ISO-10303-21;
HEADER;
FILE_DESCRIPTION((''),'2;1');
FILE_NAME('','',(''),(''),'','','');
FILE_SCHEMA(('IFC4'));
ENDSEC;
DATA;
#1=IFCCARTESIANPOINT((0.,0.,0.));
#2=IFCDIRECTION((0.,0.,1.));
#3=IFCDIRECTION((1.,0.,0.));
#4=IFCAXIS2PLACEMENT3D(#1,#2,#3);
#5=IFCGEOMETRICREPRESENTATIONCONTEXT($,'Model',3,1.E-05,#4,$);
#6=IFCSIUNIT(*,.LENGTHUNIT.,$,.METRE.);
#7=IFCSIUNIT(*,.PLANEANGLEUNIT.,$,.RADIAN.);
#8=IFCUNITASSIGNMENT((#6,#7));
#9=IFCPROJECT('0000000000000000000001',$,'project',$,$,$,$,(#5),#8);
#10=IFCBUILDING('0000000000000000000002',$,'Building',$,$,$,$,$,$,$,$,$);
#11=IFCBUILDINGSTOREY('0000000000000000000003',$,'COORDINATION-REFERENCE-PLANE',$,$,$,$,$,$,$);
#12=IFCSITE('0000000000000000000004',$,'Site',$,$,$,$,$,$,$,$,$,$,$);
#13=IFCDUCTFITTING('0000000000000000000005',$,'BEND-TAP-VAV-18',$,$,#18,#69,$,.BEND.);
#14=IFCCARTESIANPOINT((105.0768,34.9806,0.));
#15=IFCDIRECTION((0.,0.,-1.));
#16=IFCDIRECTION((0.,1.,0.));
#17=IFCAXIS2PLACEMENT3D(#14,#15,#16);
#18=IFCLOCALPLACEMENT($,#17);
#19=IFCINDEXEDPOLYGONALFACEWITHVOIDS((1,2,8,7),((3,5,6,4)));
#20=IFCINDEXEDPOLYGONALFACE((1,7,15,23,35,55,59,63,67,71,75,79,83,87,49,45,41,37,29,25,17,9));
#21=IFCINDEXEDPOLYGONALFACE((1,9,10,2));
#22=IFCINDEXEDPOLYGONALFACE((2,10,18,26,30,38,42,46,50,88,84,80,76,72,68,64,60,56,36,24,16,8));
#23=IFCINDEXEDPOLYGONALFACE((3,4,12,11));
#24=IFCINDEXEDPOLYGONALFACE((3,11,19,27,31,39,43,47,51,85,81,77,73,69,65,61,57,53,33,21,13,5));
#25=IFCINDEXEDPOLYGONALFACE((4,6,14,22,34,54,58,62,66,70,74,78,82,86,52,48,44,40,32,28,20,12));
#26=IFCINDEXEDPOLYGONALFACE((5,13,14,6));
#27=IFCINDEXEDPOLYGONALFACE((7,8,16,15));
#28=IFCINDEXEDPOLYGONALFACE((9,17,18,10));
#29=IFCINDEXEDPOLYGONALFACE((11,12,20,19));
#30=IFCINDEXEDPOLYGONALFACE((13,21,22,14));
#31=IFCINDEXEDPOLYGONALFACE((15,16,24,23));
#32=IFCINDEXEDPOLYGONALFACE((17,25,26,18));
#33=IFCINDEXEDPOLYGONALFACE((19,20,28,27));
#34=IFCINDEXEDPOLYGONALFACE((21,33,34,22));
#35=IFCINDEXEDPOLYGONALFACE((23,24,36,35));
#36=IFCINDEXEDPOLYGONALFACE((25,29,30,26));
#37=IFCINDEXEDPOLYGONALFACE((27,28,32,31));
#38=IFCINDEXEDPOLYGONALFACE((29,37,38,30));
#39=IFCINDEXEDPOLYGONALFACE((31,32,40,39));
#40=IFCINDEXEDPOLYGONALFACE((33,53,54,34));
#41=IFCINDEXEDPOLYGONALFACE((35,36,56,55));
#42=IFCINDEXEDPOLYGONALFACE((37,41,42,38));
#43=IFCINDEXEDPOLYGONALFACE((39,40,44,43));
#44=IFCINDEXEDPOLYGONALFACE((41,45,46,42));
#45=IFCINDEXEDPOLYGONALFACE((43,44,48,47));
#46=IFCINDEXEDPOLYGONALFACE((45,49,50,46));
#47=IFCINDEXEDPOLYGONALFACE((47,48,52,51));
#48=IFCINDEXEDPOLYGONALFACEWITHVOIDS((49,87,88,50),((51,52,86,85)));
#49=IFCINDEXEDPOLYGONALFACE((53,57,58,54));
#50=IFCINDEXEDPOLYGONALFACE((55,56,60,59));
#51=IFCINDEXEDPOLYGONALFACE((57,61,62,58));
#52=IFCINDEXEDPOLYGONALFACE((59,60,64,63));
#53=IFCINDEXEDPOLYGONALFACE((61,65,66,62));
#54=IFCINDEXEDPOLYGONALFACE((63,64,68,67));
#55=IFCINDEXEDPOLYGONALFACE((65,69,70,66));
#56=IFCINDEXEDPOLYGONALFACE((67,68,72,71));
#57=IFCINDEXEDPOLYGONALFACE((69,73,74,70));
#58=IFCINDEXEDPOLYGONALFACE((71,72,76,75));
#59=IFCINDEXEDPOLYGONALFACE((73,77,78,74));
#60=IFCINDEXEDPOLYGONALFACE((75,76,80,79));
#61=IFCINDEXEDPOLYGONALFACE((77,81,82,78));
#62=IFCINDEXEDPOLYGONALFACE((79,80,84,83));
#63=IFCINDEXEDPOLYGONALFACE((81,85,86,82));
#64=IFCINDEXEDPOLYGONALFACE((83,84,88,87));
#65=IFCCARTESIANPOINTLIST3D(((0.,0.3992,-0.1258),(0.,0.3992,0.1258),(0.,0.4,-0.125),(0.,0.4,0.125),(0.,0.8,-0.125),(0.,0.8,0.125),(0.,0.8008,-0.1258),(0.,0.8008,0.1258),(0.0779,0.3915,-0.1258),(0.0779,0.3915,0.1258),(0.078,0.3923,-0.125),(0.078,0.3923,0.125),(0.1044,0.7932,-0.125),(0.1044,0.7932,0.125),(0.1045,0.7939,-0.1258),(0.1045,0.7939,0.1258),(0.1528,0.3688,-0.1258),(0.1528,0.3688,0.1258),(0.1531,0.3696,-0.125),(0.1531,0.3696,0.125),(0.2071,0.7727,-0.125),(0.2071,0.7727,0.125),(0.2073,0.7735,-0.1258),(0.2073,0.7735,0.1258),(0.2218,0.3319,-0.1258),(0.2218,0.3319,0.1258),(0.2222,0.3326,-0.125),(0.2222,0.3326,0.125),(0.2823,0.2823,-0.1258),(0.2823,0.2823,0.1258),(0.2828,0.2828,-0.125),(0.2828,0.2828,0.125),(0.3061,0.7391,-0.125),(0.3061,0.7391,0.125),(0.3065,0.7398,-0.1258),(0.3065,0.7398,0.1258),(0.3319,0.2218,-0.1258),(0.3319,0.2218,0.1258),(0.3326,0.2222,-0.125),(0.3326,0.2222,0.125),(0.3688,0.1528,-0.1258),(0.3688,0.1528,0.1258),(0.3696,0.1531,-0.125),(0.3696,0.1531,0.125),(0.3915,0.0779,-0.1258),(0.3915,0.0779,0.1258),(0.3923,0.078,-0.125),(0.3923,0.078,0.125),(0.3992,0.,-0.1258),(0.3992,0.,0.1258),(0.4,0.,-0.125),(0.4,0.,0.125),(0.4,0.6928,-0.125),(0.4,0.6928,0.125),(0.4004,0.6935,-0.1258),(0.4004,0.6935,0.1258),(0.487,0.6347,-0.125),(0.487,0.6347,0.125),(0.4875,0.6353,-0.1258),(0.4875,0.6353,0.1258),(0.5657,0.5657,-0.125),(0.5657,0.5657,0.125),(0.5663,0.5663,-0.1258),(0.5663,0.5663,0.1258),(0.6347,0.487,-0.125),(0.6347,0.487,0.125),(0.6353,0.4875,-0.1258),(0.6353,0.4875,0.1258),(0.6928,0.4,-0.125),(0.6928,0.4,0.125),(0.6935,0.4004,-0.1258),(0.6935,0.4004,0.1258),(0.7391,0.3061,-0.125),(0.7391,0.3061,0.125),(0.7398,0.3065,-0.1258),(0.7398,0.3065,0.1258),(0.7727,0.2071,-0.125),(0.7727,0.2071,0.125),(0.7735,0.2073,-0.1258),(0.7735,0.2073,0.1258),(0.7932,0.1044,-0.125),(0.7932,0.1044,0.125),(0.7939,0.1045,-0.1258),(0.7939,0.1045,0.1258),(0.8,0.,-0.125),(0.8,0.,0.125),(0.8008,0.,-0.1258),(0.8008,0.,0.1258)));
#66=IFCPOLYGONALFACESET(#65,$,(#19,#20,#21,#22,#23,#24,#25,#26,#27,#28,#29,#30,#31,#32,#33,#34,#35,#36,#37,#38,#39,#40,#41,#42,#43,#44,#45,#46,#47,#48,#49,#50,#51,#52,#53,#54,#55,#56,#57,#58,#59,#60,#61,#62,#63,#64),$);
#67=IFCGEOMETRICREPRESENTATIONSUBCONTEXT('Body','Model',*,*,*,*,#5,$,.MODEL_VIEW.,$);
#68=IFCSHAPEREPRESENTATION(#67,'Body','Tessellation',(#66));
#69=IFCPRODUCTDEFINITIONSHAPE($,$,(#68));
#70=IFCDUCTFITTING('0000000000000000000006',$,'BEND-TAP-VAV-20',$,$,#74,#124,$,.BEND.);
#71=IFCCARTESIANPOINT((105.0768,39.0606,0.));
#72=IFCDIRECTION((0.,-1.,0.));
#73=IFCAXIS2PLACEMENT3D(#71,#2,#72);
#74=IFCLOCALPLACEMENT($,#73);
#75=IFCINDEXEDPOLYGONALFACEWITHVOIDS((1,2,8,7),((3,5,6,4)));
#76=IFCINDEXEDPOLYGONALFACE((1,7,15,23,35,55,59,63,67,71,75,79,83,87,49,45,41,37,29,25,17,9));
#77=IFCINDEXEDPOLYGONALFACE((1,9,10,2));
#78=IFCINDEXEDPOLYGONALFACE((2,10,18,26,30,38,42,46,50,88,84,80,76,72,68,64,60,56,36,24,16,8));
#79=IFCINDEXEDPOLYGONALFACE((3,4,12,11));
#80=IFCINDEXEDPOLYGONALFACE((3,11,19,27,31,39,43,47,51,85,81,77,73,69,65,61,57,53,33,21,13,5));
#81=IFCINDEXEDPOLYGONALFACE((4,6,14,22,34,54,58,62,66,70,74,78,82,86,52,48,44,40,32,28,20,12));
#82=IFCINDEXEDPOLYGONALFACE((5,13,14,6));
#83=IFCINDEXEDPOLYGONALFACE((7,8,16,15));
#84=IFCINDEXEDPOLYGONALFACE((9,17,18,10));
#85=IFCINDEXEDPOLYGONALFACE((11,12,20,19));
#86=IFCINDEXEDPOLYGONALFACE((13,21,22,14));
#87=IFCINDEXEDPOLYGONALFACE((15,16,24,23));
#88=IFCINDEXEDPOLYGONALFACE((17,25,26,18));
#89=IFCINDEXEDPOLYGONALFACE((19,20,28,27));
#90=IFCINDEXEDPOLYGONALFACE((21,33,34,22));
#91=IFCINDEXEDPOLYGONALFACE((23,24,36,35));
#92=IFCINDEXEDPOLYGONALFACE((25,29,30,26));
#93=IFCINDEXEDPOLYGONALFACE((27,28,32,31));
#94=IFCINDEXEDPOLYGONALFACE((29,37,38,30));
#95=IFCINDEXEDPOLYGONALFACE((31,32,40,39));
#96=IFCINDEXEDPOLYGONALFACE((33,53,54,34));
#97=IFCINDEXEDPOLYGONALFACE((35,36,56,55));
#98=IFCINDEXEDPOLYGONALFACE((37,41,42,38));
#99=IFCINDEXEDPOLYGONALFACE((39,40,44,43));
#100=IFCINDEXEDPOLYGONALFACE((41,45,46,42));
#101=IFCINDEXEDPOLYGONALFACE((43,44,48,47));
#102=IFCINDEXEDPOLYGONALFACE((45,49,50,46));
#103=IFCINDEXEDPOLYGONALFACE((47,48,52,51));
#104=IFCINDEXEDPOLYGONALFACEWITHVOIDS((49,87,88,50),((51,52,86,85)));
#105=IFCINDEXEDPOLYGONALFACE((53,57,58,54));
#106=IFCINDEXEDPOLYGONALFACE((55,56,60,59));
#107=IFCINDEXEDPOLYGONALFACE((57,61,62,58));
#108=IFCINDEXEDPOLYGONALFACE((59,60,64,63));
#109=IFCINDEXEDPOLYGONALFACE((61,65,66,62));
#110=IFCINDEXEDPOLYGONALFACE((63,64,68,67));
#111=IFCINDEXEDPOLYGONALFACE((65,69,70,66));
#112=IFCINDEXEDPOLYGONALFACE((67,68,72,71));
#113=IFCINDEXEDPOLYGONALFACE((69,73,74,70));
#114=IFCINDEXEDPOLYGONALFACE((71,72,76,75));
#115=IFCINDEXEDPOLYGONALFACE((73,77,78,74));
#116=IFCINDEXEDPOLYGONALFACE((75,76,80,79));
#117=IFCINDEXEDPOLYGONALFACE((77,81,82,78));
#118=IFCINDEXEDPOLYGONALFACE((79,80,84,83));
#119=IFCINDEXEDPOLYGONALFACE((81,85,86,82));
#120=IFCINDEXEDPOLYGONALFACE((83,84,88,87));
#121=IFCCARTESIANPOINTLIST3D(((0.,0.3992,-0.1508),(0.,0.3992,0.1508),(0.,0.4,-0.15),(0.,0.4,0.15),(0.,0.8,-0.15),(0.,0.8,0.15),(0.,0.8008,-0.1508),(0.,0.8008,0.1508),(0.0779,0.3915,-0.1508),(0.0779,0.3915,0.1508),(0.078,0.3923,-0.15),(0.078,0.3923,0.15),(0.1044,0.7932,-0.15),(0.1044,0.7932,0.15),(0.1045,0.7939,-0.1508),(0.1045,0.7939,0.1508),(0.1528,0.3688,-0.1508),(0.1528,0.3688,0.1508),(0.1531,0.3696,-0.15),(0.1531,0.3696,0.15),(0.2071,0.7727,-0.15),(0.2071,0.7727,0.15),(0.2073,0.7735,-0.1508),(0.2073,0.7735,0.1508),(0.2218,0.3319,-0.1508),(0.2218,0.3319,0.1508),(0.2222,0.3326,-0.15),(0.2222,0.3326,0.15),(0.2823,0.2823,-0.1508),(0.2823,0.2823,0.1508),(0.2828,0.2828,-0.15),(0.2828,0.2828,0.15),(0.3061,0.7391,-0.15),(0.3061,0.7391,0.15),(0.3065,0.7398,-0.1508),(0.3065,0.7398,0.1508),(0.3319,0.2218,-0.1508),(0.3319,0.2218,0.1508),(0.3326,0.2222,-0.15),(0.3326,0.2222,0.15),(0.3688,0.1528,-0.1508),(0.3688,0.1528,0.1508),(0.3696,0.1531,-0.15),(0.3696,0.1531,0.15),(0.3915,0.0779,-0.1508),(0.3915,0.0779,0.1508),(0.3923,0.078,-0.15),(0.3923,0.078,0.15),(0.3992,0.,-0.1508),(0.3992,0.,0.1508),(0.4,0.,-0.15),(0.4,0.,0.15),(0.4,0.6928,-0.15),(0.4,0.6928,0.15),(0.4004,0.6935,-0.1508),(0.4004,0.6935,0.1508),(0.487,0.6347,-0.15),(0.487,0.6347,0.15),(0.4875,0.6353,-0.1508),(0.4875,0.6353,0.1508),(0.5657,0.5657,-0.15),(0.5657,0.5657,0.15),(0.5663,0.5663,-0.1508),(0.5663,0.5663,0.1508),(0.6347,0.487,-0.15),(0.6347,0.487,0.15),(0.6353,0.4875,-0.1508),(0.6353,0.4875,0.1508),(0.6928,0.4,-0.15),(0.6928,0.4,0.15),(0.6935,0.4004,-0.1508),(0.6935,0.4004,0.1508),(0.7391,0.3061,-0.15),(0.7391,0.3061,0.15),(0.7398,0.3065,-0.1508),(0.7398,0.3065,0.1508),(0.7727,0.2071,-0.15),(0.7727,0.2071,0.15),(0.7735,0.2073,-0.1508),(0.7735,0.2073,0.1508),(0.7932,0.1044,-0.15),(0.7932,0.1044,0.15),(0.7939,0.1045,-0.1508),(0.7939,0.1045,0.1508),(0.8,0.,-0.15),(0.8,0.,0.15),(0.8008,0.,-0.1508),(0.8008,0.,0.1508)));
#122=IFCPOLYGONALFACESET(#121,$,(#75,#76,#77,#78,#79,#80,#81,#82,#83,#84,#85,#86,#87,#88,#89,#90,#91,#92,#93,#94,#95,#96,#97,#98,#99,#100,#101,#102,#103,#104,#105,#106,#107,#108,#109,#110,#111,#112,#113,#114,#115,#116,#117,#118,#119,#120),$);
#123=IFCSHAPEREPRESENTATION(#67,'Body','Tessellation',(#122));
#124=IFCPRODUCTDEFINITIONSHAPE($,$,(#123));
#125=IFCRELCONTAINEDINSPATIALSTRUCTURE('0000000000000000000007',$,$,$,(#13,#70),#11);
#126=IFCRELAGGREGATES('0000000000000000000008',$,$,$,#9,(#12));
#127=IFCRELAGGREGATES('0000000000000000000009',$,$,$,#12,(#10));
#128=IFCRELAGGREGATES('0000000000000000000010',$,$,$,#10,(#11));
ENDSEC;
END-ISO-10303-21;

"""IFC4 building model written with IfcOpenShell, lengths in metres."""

from ifc_helpers import new_model, entity, si_unit, frame, origin_with_axes, place, context, subcontext, project, spatial, element, save


model = new_model("IFC4")

# Units and contexts
model_context = context("Model", 3, precision=1e-05, world=origin_with_axes())
body_context_1 = subcontext(model_context, "Body", "Model", "MODEL_VIEW")
ifc_project = project(units=[si_unit("LENGTHUNIT", "METRE"), si_unit("PLANEANGLEUNIT", "RADIAN")], contexts=[model_context])

# Site, building, storey
site = spatial("IfcSite", under=ifc_project, Name="Site")
building = spatial("IfcBuilding", under=site, Name="Building")
storey = spatial("IfcBuildingStorey", under=building, Name="COORDINATION-REFERENCE-PLANE")

# Duct fittings
duct_fitting_1_placement = place(None, frame((105.0768, 34.9806, 0.0), z_axis=(0.0, 0.0, -1.0), x_axis=(0.0, 1.0, 0.0)))
cartesian_point_1 = entity("IfcCartesianPoint", [0.0, 0.0, 0.0])
element("IfcDuctFitting", 1, at=duct_fitting_1_placement, inside=storey, Name="BEND-TAP-VAV-18", PredefinedType="BEND", context=body_context_1, shape_type="SweptSolid", body=[
    entity("IfcRevolvedAreaSolid", entity("IfcRectangleHollowProfileDef", "AREA", None, entity("IfcAxis2Placement2D", entity("IfcCartesianPoint", [0.6, 0.0])), 0.4016, 0.2516, 0.0008), entity("IfcAxis2Placement3D", cartesian_point_1, entity("IfcDirection", [0.0, -1.0, 0.0]), entity("IfcDirection", [1.0, 0.0, 0.0])), entity("IfcAxis1Placement", cartesian_point_1, entity("IfcDirection", [0.0, 1.0, 0.0])), 1.570796),
])
duct_fitting_2_placement = place(None, frame((105.0768, 39.0606, 0.0), z_axis=(0.0, 0.0, 1.0), x_axis=(0.0, -1.0, 0.0)))
cartesian_point_2 = entity("IfcCartesianPoint", [0.0, 0.0, 0.0])
element("IfcDuctFitting", 2, at=duct_fitting_2_placement, inside=storey, Name="BEND-TAP-VAV-20", PredefinedType="BEND", context=body_context_1, shape_type="SweptSolid", body=[
    entity("IfcRevolvedAreaSolid", entity("IfcRectangleHollowProfileDef", "AREA", None, entity("IfcAxis2Placement2D", entity("IfcCartesianPoint", [0.6, 0.0])), 0.4016, 0.3016, 0.0008), entity("IfcAxis2Placement3D", cartesian_point_2, entity("IfcDirection", [0.0, -1.0, 0.0]), entity("IfcDirection", [1.0, 0.0, 0.0])), entity("IfcAxis1Placement", cartesian_point_2, entity("IfcDirection", [0.0, 1.0, 0.0])), 1.570796),
])

save(model, "model.ifc")
